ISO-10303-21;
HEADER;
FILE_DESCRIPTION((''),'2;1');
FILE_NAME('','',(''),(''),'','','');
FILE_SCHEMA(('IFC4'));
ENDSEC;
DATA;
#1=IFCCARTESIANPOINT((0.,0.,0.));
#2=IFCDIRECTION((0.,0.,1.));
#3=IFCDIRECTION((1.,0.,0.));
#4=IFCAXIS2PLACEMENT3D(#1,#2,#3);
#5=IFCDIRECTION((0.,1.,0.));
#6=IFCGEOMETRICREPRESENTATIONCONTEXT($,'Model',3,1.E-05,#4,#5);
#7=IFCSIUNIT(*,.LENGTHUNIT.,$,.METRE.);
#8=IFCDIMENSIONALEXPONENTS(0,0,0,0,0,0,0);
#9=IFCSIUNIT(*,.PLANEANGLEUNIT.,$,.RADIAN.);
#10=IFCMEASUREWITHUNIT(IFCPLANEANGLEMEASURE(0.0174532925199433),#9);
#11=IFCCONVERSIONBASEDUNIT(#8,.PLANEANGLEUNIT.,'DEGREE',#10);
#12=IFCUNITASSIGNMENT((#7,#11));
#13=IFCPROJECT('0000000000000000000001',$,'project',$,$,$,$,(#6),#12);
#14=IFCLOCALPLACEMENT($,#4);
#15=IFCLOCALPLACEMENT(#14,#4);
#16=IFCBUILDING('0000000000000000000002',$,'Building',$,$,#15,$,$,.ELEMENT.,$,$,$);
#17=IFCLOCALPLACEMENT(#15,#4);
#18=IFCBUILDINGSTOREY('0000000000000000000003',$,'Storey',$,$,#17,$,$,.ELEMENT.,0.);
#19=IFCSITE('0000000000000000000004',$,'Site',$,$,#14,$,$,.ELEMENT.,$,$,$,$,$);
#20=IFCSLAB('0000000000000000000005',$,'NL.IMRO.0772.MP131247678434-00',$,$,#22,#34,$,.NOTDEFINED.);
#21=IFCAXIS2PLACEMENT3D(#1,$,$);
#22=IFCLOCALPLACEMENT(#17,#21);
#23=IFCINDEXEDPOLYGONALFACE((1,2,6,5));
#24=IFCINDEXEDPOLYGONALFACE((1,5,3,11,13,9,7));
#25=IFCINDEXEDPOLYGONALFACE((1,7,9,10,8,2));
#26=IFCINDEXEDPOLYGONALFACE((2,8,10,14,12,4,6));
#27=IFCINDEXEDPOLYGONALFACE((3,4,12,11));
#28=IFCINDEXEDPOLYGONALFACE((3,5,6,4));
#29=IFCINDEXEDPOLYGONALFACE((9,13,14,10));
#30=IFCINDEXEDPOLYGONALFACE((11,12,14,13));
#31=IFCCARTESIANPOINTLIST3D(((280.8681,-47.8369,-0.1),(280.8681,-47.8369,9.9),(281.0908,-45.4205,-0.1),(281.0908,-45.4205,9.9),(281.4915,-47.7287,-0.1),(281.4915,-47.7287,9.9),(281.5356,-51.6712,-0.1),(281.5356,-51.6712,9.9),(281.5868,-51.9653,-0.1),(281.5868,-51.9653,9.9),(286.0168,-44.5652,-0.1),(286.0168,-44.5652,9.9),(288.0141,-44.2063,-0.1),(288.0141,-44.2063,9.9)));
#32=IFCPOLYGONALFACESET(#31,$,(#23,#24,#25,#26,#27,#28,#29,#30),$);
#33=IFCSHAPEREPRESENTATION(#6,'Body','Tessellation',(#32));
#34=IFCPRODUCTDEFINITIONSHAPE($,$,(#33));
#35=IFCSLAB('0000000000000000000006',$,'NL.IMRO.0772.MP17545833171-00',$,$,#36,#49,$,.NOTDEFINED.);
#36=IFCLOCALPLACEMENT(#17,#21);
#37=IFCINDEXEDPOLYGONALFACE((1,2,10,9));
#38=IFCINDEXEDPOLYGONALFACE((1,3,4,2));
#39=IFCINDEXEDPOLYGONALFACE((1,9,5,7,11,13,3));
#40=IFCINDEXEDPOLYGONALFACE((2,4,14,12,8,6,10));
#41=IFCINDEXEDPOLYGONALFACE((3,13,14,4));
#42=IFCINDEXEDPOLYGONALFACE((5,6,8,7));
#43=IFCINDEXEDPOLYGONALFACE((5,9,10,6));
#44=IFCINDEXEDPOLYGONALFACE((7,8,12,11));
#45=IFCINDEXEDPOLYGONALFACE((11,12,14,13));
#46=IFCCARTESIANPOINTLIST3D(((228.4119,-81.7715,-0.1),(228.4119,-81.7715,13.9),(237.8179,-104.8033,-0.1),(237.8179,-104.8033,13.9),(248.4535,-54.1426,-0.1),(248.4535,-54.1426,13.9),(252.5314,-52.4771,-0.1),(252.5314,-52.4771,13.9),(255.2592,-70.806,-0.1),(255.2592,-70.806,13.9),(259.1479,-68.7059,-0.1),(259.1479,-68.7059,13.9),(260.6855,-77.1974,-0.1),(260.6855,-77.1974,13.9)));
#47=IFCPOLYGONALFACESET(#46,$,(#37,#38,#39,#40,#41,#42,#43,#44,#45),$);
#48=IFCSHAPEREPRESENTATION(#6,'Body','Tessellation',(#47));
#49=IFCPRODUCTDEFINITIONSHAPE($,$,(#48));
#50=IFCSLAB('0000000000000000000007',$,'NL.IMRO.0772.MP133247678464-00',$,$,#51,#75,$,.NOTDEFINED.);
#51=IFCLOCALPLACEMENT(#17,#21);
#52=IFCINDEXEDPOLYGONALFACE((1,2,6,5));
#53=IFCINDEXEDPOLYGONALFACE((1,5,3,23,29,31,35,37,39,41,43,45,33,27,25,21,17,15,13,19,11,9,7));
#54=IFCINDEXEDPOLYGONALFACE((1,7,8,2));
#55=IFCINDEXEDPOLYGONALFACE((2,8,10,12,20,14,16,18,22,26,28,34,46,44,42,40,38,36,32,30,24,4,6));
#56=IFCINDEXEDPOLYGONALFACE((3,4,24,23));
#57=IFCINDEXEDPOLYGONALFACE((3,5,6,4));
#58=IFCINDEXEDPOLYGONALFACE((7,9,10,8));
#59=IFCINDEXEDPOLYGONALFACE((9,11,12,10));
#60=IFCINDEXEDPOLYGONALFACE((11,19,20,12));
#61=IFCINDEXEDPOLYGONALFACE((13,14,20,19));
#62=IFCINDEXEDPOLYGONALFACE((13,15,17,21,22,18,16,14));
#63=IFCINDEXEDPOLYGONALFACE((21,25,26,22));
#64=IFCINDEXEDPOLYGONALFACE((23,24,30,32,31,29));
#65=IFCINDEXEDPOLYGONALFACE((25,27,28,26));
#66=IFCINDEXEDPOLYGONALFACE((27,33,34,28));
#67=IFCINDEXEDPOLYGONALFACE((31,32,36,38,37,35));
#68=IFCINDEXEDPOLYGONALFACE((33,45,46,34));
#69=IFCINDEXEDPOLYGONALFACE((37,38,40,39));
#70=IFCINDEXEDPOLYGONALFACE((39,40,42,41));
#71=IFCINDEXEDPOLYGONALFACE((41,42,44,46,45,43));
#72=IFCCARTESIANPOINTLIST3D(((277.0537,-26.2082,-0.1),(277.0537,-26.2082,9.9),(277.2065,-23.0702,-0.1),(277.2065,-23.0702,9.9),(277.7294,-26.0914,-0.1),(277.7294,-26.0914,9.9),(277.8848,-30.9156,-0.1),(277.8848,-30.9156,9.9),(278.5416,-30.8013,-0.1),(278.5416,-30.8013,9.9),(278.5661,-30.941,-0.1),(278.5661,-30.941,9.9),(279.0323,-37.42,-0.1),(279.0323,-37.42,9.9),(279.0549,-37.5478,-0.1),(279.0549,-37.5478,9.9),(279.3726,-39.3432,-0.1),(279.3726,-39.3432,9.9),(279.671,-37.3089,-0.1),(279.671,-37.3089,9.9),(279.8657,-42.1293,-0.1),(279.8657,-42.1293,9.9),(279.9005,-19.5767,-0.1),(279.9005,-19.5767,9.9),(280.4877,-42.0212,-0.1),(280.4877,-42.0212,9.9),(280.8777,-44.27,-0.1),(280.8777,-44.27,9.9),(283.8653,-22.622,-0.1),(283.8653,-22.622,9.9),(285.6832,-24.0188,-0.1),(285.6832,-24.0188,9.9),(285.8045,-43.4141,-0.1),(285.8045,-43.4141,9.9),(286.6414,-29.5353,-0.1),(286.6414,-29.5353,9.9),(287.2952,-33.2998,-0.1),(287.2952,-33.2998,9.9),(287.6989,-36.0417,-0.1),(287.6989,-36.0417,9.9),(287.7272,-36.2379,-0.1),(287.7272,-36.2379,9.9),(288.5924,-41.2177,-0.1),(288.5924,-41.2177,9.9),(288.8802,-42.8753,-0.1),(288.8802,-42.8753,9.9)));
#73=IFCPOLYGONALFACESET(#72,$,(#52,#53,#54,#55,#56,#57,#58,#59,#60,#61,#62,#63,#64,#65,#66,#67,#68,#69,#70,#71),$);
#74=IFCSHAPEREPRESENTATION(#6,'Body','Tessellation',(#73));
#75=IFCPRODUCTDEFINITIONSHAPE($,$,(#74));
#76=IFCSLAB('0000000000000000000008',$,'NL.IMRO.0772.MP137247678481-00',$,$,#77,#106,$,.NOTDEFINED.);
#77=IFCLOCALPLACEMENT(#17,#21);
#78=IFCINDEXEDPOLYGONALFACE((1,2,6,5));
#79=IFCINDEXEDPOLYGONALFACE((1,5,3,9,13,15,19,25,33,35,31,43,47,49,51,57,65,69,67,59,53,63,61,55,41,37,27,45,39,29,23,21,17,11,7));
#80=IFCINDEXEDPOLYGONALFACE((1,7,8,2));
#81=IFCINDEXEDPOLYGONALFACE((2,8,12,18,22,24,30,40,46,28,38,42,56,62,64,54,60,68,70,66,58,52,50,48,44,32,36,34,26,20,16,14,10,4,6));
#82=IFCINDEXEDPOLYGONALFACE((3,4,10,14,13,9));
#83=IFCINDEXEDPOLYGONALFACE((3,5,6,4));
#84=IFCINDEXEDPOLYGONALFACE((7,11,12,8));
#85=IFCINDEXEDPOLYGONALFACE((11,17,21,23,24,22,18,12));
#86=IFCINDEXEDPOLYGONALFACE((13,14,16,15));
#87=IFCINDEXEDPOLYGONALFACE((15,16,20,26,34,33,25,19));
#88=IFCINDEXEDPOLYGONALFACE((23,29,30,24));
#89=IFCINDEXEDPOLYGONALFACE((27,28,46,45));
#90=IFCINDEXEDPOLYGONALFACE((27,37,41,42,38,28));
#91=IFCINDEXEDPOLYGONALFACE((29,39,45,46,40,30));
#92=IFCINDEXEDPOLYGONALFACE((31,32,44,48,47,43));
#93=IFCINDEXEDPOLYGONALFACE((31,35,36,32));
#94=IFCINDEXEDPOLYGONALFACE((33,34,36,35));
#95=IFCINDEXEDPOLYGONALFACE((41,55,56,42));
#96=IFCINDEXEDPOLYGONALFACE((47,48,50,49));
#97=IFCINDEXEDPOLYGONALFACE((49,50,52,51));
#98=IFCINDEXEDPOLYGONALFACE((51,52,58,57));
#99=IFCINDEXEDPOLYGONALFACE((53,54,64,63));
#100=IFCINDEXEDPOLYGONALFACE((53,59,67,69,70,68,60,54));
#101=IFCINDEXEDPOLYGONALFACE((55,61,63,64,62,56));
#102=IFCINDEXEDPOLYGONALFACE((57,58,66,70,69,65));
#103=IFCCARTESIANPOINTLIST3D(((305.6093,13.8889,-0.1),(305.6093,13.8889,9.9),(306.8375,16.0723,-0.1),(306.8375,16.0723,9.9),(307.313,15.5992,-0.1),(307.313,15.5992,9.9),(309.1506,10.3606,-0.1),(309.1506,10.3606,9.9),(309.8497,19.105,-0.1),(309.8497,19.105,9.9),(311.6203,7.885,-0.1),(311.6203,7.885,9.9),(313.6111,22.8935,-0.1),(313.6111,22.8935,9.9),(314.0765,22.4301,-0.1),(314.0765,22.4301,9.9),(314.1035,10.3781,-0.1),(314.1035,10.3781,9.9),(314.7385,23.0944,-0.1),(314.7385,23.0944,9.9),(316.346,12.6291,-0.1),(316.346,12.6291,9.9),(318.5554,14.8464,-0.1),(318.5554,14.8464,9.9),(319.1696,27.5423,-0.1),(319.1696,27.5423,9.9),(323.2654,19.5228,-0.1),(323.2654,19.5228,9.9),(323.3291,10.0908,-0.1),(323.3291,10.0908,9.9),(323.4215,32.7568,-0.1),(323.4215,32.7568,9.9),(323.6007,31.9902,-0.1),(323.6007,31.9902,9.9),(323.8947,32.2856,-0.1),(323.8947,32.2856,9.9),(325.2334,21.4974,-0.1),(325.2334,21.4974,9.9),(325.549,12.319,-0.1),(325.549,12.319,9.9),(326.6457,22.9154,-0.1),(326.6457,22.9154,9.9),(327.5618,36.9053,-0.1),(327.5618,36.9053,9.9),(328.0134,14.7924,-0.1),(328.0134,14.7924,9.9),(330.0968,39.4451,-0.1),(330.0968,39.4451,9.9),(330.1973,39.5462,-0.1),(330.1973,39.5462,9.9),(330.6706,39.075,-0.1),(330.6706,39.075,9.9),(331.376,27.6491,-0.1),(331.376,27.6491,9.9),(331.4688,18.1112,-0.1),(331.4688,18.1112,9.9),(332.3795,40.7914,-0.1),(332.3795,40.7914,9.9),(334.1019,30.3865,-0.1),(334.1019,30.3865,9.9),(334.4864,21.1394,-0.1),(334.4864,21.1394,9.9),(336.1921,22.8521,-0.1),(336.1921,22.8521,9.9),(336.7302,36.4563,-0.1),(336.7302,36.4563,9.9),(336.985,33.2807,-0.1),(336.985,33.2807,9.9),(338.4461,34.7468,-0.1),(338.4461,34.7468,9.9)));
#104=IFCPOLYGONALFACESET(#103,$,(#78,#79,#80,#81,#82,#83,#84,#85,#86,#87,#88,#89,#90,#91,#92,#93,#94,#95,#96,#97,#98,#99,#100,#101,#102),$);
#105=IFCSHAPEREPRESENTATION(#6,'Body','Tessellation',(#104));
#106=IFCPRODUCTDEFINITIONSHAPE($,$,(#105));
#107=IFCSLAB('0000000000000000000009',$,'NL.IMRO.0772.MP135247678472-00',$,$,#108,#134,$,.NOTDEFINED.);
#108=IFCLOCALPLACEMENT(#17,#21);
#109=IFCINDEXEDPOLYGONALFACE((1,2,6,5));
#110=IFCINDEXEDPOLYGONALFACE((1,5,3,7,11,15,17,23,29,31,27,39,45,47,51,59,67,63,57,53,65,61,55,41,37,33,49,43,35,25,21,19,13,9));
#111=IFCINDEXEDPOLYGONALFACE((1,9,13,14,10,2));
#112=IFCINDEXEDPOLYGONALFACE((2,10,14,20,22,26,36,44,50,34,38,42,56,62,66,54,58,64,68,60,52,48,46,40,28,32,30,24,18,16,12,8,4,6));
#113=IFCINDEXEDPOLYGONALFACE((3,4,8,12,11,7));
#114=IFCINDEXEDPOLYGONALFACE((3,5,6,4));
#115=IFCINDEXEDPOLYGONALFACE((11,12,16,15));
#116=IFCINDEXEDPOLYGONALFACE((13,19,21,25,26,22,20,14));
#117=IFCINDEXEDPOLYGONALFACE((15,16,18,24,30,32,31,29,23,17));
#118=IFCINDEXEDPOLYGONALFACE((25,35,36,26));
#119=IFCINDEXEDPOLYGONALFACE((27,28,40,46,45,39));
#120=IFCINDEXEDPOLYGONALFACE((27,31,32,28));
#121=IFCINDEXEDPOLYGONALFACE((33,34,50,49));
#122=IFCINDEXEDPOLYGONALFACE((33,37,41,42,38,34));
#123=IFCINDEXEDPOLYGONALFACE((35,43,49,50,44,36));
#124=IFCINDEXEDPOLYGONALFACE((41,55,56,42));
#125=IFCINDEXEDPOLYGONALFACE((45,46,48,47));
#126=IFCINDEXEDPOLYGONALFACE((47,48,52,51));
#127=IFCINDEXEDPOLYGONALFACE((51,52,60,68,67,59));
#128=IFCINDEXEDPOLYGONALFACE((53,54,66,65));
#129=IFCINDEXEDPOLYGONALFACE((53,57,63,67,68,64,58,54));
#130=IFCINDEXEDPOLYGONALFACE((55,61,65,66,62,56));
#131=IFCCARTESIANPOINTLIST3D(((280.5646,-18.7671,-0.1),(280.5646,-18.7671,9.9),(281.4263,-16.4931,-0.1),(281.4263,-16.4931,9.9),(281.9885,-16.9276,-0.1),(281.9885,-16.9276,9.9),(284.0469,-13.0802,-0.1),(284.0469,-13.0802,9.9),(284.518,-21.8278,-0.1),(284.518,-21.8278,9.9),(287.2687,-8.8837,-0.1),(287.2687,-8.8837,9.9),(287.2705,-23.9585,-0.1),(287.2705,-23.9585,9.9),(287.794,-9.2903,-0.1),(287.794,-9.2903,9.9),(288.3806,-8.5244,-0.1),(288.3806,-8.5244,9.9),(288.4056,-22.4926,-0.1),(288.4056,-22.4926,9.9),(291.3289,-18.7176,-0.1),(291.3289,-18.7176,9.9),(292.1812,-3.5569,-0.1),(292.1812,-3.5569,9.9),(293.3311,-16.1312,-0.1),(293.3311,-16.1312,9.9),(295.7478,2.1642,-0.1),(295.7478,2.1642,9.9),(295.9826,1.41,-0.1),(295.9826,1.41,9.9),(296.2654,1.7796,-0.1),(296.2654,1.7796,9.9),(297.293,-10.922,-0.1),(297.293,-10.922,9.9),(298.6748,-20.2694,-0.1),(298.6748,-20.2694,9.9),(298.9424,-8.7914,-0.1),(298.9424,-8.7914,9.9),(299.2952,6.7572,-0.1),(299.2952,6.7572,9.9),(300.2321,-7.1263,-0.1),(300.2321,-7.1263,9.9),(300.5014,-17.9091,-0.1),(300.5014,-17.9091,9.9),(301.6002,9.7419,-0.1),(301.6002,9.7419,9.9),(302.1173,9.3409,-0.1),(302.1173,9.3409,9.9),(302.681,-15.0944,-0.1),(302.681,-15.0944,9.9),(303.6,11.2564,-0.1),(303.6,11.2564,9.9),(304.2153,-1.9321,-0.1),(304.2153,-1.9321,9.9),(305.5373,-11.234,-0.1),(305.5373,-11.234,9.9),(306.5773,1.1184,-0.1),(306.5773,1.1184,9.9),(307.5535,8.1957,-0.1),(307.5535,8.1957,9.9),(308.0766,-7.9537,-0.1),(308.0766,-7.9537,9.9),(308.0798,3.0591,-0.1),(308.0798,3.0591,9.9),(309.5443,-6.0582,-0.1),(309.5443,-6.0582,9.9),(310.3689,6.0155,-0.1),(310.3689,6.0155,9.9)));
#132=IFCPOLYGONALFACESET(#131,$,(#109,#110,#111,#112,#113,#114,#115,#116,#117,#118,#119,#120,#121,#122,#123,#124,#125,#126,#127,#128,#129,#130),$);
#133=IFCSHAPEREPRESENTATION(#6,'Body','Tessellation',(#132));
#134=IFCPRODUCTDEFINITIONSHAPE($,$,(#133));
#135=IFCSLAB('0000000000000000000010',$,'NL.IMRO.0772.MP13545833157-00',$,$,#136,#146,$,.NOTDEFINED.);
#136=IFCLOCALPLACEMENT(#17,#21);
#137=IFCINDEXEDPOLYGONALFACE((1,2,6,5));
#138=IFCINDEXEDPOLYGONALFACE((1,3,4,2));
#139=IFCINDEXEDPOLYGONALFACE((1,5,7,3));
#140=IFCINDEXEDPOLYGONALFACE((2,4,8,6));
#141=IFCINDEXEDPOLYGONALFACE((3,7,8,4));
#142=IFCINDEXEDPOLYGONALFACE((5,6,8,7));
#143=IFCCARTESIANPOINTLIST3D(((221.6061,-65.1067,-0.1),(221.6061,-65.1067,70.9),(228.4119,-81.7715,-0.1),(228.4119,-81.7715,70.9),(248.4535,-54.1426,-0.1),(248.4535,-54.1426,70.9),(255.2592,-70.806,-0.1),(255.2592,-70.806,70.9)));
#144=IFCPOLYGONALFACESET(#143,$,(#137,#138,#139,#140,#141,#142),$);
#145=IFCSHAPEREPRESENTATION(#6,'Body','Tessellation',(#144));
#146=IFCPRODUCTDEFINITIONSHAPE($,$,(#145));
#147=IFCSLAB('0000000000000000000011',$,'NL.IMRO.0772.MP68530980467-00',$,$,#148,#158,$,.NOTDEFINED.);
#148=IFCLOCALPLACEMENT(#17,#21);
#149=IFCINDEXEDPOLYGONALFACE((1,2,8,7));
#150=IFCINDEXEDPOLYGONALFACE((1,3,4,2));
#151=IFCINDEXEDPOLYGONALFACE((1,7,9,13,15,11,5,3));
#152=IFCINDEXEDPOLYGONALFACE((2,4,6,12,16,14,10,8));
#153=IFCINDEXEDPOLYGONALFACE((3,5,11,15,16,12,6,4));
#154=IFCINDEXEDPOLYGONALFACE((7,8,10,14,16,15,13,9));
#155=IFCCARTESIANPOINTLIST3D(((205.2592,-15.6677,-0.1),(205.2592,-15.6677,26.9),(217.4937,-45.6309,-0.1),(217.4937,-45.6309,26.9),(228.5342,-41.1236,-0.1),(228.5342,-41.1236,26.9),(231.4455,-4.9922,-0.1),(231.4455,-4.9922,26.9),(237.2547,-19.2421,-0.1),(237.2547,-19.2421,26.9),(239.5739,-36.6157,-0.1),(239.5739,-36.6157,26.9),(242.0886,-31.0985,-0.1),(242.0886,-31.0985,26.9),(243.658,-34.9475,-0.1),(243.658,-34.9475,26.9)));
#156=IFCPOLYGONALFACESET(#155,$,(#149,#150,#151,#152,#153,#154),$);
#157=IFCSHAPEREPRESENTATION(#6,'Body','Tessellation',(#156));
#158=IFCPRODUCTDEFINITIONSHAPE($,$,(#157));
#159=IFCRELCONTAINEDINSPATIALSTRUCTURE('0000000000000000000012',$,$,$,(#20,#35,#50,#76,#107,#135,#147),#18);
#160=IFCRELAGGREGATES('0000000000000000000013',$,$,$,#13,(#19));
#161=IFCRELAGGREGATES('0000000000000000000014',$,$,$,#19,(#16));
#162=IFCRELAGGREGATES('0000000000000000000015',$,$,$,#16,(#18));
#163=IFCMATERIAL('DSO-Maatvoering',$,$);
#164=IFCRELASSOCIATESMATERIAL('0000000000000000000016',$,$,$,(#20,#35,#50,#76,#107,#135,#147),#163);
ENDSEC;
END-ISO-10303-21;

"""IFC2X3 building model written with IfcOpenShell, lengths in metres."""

from ifc_helpers import new_model, entity, si_unit, converted_unit, direction, frame, origin_with_axes, place, context, project, spatial, polyline, outline, extrude, material, element, save


model = new_model("IFC2X3")

# Units and contexts
model_context = context("Model", 3, precision=1e-05, world=origin_with_axes(), true_north=direction((0.0, 1.0, 0.0)))
ifc_project = project(units=[si_unit("LENGTHUNIT", "METRE"), converted_unit("PLANEANGLEUNIT", "DEGREE", entity("IfcPlaneAngleMeasure", 0.0174532925199433), si_unit("PLANEANGLEUNIT", "RADIAN"), dimensions=[0, 0, 0, 0, 0, 0, 0])], contexts=[model_context])

# Site, building, storey
site_placement = place(None, origin_with_axes())
site = spatial("IfcSite", under=ifc_project, at=site_placement, Name="Site", CompositionType="ELEMENT")
building_placement = place(site_placement, origin_with_axes())
building = spatial("IfcBuilding", under=site, at=building_placement, Name="Building", CompositionType="ELEMENT")
storey_placement = place(building_placement, origin_with_axes())
storey = spatial("IfcBuildingStorey", under=building, at=storey_placement, Name="Storey", CompositionType="ELEMENT", Elevation=0.0)

# Slabs
ifc_material = material(Name="DSO-Maatvoering")
slab_1_placement = place(storey_placement, frame((0.0, 0.0, -0.1), z_axis=(0.0, 0.0, 1.0), x_axis=(1.0, 0.0, 0.0)))
element("IfcSlab", 1, at=slab_1_placement, inside=storey, material=ifc_material, Name="NL.IMRO.0772.MP131247678434-00", PredefinedType="NOTDEFINED", context=model_context, shape_type="SweptSolid", body=[
    extrude(outline(polyline([(281.5356, -51.6712), (280.8681, -47.8369), (281.4915, -47.7287), (281.0908, -45.4205), (286.0168, -44.5652), (288.0141, -44.2063), (281.5868, -51.9653), (281.5356, -51.6712)])), origin_with_axes(), (0.0, 0.0, 1.0), 10.0),
])
for number, where, z_axis, x_axis, name in (
    (2, (0.0, 0.0, -0.1), (0.0, 0.0, 1.0), (1.0, 0.0, 0.0), "NL.IMRO.0772.MP17545833171-00"),
):
    element("IfcSlab", number, at=place(storey_placement, frame(where, z_axis=z_axis, x_axis=x_axis)), inside=storey, material=ifc_material, Name=name, PredefinedType="NOTDEFINED", context=model_context, shape_type="SweptSolid", body=[
        extrude(outline(polyline([(228.4119, -81.7715), (255.2592, -70.806), (248.4535, -54.1426), (252.5314, -52.4771), (259.1479, -68.7059), (260.6855, -77.1974), (237.8179, -104.8033), (228.4119, -81.7715)])), origin_with_axes(), (0.0, 0.0, 1.0), 14.0),
    ])
slab_2_placement = place(storey_placement, frame((0.0, 0.0, -0.1), z_axis=(0.0, 0.0, 1.0), x_axis=(1.0, 0.0, 0.0)))
element("IfcSlab", 3, at=slab_2_placement, inside=storey, material=ifc_material, Name="NL.IMRO.0772.MP133247678464-00", PredefinedType="NOTDEFINED", context=model_context, shape_type="SweptSolid", body=[
    extrude(outline(polyline([(287.7272, -36.2379), (288.5924, -41.2177), (288.8802, -42.8753), (285.8045, -43.4141), (280.8777, -44.27), (280.4877, -42.0212), (279.8657, -42.1293), (279.3726, -39.3432), (279.0549, -37.5478), (279.0323, -37.42), (279.671, -37.3089), (278.5661, -30.941), (278.5416, -30.8013), (277.8848, -30.9156), (277.0537, -26.2082), (277.7294, -26.0914), (277.2065, -23.0702), (279.9005, -19.5767), (283.8653, -22.622), (285.6832, -24.0188), (286.6414, -29.5353), (287.2952, -33.2998), (287.6989, -36.0417), (287.7272, -36.2379)])), origin_with_axes(), (0.0, 0.0, 1.0), 10.0),
])
slab_3_placement = place(storey_placement, frame((0.0, 0.0, -0.1), z_axis=(0.0, 0.0, 1.0), x_axis=(1.0, 0.0, 0.0)))
element("IfcSlab", 4, at=slab_3_placement, inside=storey, material=ifc_material, Name="NL.IMRO.0772.MP137247678481-00", PredefinedType="NOTDEFINED", context=model_context, shape_type="SweptSolid", body=[
    extrude(outline(polyline([(330.6706, 39.075), (332.3795, 40.7914), (336.7302, 36.4563), (338.4461, 34.7468), (336.985, 33.2807), (334.1019, 30.3865), (331.376, 27.6491), (336.1921, 22.8521), (334.4864, 21.1394), (331.4688, 18.1112), (326.6457, 22.9154), (325.2334, 21.4974), (323.2654, 19.5228), (328.0134, 14.7924), (325.549, 12.319), (323.3291, 10.0908), (318.5554, 14.8464), (316.346, 12.6291), (314.1035, 10.3781), (311.6203, 7.885), (309.1506, 10.3606), (305.6093, 13.8889), (307.313, 15.5992), (306.8375, 16.0723), (309.8497, 19.105), (313.6111, 22.8935), (314.0765, 22.4301), (314.7385, 23.0944), (319.1696, 27.5423), (323.6007, 31.9902), (323.8947, 32.2856), (323.4215, 32.7568), (327.5618, 36.9053), (330.0968, 39.4451), (330.1973, 39.5462), (330.6706, 39.075)])), origin_with_axes(), (0.0, 0.0, 1.0), 10.0),
])
slab_4_placement = place(storey_placement, frame((0.0, 0.0, -0.1), z_axis=(0.0, 0.0, 1.0), x_axis=(1.0, 0.0, 0.0)))
element("IfcSlab", 5, at=slab_4_placement, inside=storey, material=ifc_material, Name="NL.IMRO.0772.MP135247678472-00", PredefinedType="NOTDEFINED", context=model_context, shape_type="SweptSolid", body=[
    extrude(outline(polyline([(287.2705, -23.9585), (284.518, -21.8278), (280.5646, -18.7671), (281.9885, -16.9276), (281.4263, -16.4931), (284.0469, -13.0802), (287.2687, -8.8837), (287.794, -9.2903), (288.3806, -8.5244), (292.1812, -3.5569), (295.9826, 1.41), (296.2654, 1.7796), (295.7478, 2.1642), (299.2952, 6.7572), (301.6002, 9.7419), (302.1173, 9.3409), (303.6, 11.2564), (307.5535, 8.1957), (310.3689, 6.0155), (308.0798, 3.0591), (306.5773, 1.1184), (304.2153, -1.9321), (309.5443, -6.0582), (308.0766, -7.9537), (305.5373, -11.234), (300.2321, -7.1263), (298.9424, -8.7914), (297.293, -10.922), (302.681, -15.0944), (300.5014, -17.9091), (298.6748, -20.2694), (293.3311, -16.1312), (291.3289, -18.7176), (288.4056, -22.4926), (287.2705, -23.9585)])), origin_with_axes(), (0.0, 0.0, 1.0), 10.0),
])
for number, where, z_axis, x_axis, name in (
    (6, (0.0, 0.0, -0.1), (0.0, 0.0, 1.0), (1.0, 0.0, 0.0), "NL.IMRO.0772.MP13545833157-00"),
):
    element("IfcSlab", number, at=place(storey_placement, frame(where, z_axis=z_axis, x_axis=x_axis)), inside=storey, material=ifc_material, Name=name, PredefinedType="NOTDEFINED", context=model_context, shape_type="SweptSolid", body=[
        extrude(outline(polyline([(248.4535, -54.1426), (255.2592, -70.806), (228.4119, -81.7715), (221.6061, -65.1067), (248.4535, -54.1426)])), origin_with_axes(), (0.0, 0.0, 1.0), 71.0),
    ])
for number, where, z_axis, x_axis, name in (
    (7, (0.0, 0.0, -0.1), (0.0, 0.0, 1.0), (1.0, 0.0, 0.0), "NL.IMRO.0772.MP68530980467-00"),
):
    element("IfcSlab", number, at=place(storey_placement, frame(where, z_axis=z_axis, x_axis=x_axis)), inside=storey, material=ifc_material, Name=name, PredefinedType="NOTDEFINED", context=model_context, shape_type="SweptSolid", body=[
        extrude(outline(polyline([(243.658, -34.9475), (239.5739, -36.6157), (228.5342, -41.1236), (217.4937, -45.6309), (205.2592, -15.6677), (231.4455, -4.9922), (237.2547, -19.2421), (242.0886, -31.0985), (243.658, -34.9475)])), origin_with_axes(), (0.0, 0.0, 1.0), 27.0),
    ])

save(model, "model.ifc")
